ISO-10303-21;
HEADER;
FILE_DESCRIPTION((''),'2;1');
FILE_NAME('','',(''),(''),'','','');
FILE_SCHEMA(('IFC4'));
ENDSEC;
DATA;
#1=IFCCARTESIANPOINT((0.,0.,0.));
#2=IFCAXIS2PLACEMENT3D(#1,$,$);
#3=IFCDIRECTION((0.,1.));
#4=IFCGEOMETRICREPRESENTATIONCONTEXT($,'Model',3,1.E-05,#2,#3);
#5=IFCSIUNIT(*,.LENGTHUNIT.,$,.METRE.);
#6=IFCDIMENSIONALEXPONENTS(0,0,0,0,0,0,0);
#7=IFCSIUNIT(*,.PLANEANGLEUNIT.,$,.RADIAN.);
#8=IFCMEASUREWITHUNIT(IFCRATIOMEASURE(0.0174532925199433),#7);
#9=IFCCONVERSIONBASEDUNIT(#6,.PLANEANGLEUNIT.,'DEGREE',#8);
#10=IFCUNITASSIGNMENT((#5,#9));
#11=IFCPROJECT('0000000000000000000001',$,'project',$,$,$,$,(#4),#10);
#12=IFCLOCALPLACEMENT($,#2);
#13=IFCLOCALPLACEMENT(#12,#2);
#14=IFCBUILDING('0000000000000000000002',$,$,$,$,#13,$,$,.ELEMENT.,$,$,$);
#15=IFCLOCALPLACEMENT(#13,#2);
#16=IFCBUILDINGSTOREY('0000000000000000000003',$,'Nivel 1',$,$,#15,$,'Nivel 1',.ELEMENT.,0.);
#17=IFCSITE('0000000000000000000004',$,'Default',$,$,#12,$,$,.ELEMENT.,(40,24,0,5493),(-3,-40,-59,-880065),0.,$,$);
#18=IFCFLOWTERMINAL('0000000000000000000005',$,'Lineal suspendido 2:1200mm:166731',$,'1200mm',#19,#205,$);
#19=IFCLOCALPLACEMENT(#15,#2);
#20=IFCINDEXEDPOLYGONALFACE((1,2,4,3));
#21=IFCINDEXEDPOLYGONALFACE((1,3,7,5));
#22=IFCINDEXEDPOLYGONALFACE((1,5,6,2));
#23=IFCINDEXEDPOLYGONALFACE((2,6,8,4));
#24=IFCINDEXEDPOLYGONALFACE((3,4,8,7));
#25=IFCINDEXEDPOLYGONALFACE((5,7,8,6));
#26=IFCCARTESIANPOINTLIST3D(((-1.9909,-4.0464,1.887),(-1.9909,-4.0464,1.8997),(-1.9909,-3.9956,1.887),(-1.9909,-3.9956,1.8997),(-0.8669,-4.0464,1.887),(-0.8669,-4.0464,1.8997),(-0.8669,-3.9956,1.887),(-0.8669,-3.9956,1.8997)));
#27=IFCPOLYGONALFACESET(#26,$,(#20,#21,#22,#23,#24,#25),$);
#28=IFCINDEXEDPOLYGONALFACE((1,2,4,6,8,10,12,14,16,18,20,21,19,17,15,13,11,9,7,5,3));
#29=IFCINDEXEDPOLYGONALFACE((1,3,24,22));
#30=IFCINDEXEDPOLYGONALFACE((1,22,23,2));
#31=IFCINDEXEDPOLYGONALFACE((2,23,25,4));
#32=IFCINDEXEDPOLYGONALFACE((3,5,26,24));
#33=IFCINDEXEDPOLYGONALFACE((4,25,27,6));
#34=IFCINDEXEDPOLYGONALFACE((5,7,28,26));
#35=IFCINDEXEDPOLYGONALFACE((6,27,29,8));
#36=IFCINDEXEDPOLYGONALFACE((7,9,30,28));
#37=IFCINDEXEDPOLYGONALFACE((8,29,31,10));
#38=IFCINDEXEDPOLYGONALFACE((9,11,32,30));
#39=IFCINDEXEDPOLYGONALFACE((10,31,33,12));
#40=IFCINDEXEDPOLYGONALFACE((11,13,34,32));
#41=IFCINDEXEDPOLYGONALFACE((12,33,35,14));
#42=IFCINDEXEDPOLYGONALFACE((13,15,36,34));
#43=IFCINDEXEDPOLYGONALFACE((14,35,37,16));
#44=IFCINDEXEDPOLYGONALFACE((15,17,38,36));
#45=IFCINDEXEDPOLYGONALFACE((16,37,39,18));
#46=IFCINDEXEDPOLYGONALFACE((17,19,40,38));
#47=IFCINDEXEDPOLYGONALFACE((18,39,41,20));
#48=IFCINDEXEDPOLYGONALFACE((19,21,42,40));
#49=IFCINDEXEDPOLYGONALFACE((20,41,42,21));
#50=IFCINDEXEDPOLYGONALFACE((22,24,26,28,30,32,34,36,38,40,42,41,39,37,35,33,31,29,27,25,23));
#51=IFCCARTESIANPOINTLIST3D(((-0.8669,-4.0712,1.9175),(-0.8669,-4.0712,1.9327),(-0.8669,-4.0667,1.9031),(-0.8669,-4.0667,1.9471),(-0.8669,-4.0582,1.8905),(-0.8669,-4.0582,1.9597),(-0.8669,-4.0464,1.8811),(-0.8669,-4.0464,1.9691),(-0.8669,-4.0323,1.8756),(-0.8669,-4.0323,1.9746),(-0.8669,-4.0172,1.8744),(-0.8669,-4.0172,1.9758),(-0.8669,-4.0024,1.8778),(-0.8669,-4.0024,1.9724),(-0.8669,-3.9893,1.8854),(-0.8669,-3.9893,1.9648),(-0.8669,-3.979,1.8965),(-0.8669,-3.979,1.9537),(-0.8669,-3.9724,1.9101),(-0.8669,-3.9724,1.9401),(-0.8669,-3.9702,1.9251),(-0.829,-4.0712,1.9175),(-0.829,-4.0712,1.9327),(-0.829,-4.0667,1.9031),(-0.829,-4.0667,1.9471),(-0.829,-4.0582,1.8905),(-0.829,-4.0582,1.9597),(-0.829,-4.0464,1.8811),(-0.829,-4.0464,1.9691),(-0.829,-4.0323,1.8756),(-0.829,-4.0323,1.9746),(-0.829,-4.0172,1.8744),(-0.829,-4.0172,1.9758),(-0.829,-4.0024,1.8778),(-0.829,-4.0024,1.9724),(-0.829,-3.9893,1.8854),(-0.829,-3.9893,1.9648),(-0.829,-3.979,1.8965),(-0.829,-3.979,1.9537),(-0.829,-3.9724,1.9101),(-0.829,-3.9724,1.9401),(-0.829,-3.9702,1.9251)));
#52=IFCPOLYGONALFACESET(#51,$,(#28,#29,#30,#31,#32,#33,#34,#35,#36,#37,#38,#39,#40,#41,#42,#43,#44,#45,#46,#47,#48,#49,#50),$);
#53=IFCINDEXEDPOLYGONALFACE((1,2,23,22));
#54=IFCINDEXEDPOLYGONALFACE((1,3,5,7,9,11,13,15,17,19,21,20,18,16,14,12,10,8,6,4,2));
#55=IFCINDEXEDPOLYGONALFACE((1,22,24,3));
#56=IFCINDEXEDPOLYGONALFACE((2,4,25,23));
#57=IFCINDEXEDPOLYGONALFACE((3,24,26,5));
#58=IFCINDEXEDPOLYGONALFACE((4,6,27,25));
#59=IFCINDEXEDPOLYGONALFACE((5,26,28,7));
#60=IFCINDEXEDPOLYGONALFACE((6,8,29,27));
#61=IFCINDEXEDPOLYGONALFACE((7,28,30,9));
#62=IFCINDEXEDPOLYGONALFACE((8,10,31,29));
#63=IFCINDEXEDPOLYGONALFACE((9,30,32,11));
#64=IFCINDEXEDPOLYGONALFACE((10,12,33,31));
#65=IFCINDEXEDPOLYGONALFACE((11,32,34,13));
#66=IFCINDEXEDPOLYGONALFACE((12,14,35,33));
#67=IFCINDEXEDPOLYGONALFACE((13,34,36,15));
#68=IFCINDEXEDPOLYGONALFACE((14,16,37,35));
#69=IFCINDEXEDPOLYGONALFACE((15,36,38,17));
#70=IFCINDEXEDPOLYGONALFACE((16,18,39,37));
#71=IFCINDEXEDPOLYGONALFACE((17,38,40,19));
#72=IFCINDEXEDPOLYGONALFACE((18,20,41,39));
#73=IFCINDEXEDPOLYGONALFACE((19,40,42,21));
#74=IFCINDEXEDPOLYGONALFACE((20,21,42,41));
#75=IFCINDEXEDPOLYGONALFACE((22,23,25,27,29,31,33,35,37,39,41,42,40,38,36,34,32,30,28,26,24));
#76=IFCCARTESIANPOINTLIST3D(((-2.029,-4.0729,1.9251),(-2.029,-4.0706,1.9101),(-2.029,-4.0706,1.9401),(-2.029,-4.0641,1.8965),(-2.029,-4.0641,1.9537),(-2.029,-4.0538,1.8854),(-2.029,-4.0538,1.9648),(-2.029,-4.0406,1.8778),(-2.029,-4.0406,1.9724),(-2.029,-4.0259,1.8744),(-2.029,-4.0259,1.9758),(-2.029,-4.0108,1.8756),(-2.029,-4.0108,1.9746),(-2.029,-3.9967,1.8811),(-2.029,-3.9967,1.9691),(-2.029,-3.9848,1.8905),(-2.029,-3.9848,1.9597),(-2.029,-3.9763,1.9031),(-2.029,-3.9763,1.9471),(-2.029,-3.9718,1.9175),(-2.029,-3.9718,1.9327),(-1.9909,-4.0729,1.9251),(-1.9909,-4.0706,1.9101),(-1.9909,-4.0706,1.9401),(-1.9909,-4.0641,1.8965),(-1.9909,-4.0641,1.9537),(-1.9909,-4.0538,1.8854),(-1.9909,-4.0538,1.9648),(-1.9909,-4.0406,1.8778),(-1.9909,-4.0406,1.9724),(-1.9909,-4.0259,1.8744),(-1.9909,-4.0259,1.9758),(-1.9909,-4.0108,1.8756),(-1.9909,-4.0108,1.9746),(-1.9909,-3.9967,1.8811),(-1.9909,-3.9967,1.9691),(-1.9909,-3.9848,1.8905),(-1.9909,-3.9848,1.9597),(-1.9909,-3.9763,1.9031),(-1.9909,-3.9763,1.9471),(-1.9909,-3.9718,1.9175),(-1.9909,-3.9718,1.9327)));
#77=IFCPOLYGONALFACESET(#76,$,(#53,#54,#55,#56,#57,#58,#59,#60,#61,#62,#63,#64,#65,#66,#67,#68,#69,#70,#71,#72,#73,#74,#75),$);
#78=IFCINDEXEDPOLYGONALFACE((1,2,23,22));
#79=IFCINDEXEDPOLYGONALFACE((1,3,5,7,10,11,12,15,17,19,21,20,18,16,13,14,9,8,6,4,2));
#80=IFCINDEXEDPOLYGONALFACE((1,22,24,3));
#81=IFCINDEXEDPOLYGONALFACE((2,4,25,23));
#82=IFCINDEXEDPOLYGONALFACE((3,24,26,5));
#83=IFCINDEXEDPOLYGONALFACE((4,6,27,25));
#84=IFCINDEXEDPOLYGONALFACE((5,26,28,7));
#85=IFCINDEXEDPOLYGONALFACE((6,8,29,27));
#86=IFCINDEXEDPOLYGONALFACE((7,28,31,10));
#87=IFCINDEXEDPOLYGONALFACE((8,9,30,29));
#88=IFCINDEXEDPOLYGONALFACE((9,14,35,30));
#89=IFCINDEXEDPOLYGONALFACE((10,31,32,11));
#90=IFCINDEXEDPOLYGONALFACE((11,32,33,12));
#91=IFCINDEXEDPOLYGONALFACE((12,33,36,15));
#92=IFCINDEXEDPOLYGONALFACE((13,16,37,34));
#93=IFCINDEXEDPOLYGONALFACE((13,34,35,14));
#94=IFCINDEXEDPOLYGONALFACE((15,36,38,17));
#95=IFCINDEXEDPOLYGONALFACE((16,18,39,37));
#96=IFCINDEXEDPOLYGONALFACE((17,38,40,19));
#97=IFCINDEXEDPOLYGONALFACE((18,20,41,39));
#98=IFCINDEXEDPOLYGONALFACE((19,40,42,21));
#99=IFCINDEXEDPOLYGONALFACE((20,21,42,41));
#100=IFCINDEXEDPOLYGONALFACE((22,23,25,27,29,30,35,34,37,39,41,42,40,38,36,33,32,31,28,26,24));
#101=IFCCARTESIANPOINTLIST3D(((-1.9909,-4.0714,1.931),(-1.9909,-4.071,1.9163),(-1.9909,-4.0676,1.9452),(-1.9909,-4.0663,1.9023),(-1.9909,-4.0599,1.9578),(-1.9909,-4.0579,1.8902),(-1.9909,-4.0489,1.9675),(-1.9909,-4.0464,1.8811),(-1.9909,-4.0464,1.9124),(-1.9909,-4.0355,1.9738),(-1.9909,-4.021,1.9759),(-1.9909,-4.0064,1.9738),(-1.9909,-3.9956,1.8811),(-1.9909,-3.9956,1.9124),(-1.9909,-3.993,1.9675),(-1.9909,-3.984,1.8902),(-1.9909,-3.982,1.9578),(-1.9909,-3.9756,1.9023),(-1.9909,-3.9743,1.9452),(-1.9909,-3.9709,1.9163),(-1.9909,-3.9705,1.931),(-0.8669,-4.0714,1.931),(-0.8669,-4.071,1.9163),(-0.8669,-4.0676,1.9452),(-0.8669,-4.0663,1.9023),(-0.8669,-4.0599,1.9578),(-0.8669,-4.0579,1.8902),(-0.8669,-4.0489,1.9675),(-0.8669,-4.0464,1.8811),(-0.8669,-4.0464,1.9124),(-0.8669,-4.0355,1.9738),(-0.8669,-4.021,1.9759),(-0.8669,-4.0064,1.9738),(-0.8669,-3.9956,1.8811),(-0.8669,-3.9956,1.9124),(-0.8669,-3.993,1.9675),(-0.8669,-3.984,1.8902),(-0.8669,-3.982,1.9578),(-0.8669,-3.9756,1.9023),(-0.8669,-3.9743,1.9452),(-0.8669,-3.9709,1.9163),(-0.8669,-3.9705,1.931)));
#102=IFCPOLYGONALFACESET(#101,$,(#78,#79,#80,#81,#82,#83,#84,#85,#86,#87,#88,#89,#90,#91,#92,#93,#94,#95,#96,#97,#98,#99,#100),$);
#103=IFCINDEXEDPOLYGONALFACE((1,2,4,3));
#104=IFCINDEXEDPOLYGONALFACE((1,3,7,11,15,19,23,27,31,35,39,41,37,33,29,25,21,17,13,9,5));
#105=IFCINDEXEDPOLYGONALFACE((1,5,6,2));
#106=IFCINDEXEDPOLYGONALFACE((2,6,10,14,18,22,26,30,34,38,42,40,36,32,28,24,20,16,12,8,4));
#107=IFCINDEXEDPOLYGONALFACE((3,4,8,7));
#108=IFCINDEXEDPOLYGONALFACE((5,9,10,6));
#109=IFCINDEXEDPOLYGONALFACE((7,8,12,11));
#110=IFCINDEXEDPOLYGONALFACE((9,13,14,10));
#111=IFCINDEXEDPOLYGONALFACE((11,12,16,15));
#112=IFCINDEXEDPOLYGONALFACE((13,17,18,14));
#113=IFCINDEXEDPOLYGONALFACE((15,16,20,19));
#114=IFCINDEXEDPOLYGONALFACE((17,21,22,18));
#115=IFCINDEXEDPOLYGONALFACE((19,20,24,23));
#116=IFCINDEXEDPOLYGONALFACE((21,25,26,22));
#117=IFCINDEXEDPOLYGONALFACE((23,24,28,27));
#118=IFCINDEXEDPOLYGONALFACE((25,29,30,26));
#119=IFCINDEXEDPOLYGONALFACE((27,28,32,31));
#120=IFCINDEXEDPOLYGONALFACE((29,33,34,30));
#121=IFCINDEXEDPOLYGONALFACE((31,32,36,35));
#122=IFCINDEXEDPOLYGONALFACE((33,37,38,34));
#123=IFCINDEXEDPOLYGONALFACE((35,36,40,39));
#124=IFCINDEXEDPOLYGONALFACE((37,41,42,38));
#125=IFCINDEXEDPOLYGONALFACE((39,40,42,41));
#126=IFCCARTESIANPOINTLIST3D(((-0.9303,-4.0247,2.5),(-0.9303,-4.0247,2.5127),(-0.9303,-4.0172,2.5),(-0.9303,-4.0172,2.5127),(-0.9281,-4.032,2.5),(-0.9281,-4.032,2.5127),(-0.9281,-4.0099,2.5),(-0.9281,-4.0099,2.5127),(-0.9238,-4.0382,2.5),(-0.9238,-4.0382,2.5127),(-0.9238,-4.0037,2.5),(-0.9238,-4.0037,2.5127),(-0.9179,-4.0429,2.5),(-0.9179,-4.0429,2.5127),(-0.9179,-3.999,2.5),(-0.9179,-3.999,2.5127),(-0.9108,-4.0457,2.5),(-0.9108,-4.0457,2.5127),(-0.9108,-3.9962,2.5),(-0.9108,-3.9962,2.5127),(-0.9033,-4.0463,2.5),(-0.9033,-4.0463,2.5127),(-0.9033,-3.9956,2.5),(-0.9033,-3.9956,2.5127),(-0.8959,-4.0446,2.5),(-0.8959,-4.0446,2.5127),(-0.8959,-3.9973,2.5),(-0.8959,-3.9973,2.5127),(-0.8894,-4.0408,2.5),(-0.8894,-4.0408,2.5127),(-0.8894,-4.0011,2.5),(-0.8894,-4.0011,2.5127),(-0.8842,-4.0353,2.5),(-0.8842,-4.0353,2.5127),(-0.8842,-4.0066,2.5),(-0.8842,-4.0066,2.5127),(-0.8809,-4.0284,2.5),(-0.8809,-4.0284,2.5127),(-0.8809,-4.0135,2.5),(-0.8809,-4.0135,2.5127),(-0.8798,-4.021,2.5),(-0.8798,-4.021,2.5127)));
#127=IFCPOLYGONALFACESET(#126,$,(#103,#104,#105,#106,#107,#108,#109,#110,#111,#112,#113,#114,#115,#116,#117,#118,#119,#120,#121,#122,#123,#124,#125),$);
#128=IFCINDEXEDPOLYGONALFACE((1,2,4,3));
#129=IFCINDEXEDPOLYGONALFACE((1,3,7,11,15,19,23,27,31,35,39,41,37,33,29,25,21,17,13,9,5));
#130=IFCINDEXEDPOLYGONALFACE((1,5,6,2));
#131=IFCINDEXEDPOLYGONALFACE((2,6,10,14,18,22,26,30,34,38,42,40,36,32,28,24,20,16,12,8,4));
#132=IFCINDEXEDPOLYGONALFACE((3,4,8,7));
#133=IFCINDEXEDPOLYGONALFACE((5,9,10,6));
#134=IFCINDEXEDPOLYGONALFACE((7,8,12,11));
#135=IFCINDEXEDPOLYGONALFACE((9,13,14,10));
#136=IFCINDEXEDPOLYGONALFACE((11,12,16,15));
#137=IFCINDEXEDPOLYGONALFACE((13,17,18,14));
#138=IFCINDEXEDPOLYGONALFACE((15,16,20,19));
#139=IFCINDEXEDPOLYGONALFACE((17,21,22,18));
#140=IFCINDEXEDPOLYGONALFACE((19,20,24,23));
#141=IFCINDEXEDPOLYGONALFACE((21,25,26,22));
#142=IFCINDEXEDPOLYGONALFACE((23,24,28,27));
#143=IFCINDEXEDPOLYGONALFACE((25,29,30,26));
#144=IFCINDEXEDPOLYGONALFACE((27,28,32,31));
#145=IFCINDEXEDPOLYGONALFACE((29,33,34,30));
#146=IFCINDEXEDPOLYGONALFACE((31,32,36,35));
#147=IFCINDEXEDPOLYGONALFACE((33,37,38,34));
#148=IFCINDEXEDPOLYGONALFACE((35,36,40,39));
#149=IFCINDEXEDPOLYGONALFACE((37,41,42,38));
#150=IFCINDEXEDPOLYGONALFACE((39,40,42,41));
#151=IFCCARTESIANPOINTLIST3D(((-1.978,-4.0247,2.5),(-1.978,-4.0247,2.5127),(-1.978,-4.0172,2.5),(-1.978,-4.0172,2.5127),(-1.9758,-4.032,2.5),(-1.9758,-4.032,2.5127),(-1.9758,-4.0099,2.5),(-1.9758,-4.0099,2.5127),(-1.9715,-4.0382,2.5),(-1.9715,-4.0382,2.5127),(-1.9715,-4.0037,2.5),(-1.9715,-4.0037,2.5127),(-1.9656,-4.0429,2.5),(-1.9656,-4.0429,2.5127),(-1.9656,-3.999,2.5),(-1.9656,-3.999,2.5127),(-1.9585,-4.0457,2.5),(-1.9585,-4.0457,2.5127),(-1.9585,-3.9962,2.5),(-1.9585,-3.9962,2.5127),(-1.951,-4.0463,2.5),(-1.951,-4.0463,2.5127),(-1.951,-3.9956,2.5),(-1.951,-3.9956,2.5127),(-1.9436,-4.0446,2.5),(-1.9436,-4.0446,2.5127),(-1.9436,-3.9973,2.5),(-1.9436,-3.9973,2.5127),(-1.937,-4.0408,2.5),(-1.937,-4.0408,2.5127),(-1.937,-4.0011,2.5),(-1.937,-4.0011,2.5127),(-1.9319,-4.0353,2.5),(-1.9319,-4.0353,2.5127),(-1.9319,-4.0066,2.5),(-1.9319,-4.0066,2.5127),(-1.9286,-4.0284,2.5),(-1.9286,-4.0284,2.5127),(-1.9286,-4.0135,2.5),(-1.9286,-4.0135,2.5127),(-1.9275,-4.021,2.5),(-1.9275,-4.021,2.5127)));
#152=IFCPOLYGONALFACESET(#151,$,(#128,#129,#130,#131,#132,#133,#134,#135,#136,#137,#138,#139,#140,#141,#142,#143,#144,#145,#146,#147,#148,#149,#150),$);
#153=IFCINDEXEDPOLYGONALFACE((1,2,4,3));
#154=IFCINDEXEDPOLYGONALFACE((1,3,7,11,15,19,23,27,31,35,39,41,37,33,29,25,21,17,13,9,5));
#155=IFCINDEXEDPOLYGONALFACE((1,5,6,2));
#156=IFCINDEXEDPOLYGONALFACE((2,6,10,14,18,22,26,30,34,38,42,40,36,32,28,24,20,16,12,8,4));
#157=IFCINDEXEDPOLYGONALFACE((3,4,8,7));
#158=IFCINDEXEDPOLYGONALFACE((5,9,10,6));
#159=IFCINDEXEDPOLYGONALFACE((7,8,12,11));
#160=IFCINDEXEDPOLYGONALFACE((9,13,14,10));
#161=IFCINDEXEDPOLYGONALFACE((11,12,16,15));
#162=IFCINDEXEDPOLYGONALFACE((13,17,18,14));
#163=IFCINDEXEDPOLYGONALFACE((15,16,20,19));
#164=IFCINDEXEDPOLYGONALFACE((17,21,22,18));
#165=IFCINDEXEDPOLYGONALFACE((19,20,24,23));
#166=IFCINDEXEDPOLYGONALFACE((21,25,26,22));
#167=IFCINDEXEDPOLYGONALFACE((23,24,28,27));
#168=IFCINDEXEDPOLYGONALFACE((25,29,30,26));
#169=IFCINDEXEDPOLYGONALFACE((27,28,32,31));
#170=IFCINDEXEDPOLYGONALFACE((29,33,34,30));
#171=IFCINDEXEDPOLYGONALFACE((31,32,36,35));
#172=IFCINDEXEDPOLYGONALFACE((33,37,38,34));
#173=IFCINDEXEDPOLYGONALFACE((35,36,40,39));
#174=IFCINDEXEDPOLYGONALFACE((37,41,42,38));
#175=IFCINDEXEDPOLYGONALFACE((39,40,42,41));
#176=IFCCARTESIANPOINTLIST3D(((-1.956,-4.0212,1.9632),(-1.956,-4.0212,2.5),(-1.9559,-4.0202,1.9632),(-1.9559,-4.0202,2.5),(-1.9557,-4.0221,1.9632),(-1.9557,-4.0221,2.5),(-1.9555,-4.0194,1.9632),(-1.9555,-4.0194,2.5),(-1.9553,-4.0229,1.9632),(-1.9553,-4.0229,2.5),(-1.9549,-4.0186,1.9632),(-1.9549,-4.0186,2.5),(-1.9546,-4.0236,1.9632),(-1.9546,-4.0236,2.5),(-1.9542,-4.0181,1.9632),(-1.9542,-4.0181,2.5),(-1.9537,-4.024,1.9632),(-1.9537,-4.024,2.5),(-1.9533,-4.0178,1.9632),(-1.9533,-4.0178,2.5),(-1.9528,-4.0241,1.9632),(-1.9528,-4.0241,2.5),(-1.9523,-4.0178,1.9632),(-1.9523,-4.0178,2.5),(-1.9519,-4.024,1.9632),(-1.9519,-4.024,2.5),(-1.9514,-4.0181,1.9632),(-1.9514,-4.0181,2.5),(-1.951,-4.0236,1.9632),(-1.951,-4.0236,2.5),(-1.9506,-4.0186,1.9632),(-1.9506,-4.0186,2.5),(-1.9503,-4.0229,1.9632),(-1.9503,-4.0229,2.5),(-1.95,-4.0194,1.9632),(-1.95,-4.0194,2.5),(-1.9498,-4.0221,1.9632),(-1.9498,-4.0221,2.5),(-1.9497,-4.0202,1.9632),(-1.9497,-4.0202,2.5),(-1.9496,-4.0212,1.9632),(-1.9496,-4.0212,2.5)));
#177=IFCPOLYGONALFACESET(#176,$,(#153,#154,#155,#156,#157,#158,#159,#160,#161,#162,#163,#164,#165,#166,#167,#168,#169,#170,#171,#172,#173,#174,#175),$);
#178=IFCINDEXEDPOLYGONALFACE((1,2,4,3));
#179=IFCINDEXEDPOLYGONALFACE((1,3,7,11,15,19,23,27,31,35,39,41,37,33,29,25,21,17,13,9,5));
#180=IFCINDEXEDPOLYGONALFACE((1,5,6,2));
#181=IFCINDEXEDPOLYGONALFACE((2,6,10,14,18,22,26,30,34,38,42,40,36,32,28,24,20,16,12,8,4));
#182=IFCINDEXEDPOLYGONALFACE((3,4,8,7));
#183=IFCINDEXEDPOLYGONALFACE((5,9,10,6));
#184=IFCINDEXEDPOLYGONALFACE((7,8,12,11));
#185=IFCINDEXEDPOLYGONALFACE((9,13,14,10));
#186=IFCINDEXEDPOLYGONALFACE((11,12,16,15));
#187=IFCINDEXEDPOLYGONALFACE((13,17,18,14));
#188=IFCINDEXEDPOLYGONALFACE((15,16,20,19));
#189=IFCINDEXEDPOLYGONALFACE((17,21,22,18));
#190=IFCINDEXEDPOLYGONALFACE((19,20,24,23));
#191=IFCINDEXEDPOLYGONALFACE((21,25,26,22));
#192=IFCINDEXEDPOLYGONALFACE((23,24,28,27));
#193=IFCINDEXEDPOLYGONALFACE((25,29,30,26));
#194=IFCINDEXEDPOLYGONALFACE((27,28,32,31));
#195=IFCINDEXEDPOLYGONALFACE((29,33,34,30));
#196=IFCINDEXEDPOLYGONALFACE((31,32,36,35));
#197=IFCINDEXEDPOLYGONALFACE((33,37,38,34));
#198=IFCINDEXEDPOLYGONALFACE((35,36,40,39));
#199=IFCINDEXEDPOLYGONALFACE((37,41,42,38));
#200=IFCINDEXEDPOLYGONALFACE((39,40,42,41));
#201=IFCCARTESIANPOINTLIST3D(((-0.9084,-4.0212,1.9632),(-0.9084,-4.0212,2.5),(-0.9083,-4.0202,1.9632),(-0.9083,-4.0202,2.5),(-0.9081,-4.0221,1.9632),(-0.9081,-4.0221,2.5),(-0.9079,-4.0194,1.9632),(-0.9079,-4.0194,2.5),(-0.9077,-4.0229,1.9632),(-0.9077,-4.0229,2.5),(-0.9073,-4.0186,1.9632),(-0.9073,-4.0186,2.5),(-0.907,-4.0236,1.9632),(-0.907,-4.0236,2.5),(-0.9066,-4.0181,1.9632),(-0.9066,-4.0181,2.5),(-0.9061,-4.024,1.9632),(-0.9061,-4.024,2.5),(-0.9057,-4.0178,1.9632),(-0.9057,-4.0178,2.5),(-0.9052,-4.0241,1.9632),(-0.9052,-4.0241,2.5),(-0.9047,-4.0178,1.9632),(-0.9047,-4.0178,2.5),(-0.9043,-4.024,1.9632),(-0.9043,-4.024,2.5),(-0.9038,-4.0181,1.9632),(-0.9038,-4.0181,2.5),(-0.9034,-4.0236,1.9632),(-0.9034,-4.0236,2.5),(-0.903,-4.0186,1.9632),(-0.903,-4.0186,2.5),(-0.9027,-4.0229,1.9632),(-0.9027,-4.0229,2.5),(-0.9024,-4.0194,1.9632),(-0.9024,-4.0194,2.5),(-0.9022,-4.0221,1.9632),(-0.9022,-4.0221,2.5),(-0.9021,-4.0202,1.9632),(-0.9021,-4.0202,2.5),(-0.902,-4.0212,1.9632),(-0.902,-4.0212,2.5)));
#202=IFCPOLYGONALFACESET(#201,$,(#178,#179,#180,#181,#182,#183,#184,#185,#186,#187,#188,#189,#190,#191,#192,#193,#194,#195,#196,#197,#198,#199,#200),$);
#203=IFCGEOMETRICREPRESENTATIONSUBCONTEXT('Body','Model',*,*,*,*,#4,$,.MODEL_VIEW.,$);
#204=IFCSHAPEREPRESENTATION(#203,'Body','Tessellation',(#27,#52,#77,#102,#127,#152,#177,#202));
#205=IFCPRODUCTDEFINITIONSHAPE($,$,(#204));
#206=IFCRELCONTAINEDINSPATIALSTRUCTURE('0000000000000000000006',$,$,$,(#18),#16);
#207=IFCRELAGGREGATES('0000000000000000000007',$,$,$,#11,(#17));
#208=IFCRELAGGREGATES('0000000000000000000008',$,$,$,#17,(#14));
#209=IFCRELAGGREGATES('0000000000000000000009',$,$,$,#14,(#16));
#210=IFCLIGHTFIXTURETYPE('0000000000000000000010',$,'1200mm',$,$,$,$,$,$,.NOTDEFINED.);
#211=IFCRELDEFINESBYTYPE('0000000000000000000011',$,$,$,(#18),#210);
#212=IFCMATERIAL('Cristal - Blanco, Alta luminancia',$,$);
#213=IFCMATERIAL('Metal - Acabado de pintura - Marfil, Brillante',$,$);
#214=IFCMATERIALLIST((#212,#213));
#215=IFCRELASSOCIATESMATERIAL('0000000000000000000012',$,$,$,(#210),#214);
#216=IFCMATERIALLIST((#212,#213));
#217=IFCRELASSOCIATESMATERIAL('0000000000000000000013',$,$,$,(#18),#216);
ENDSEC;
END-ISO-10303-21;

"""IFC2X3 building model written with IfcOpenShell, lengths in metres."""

from ifc_helpers import new_model, entity, si_unit, converted_unit, direction, frame, frame_2d, origin, origin_2d_with_axis, place, context, subcontext, project, spatial, polyline, circle_curve, parameter, trimmed, segment, composite_curve, rectangle, circle, outline, extrude, source, transform, mapped, material, material_list, type_object, type_shapes, element, save


model = new_model("IFC2X3")

# Units and contexts
model_context = context("Model", 3, precision=1e-05, world=origin(), true_north=direction((0.0, 1.0)))
body_context = subcontext(model_context, "Body", "Model", "MODEL_VIEW")
ifc_project = project(units=[si_unit("LENGTHUNIT", "METRE"), converted_unit("PLANEANGLEUNIT", "DEGREE", entity("IfcRatioMeasure", 0.0174532925199433), si_unit("PLANEANGLEUNIT", "RADIAN"), dimensions=[0, 0, 0, 0, 0, 0, 0])], contexts=[model_context])

# Site, building, storey
site_placement = place(None, origin())
site = spatial("IfcSite", under=ifc_project, at=site_placement, Name="Default", CompositionType="ELEMENT", RefLatitude=(40, 24, 0, 5493), RefLongitude=(-3, -40, -59, -880065), RefElevation=0.0)
building_placement = place(site_placement, origin())
building = spatial("IfcBuilding", under=site, at=building_placement, CompositionType="ELEMENT")
storey_placement = place(building_placement, origin())
storey = spatial("IfcBuildingStorey", under=building, at=storey_placement, Name="Nivel 1", LongName="Nivel 1", CompositionType="ELEMENT", Elevation=0.0)

# Flow terminal
ifc_material_1 = material(Name="Cristal - Blanco, Alta luminancia")
ifc_material_2 = material(Name="Metal - Acabado de pintura - Marfil, Brillante")
ifc_material_list_1 = material_list([ifc_material_1, ifc_material_2])
light_fixture_type = type_object("IfcLightFixtureType", Name="1200mm", PredefinedType="NOTDEFINED", material=ifc_material_list_1)
shared_shape = source(origin(), body_context, "Body", "SweptSolid", [
    extrude(rectangle(XDim=1.124, YDim=0.0508, at=origin_2d_with_axis()), frame((0.0001, 0.0, 1.8127), z_axis=(0.0, 0.0, 1.0), x_axis=(-1.0, 0.0, 0.0)), (0.0, 0.0, 1.0), 0.0127),
    extrude(circle(Radius=0.0508, at=frame_2d((0.0, 0.0), x_axis=(1.0, 0.0))), frame((0.5621, 0.0, 1.8508), z_axis=(1.0, 0.0, 0.0), x_axis=(0.0, 1.0, 0.0)), (0.0, 0.0, 1.0), 0.0379),
    extrude(circle(Radius=0.0508, at=frame_2d((0.0, 0.0), x_axis=(1.0, 0.0))), frame((-0.6, -0.0011, 1.8508), z_axis=(1.0, 0.0, 0.0), x_axis=(0.0, -1.0, 0.0)), (0.0, 0.0, 1.0), 0.0381),
    extrude(outline(composite_curve([segment(trimmed(circle_curve(frame_2d((0.0125, 0.0), x_axis=(0.0, 1.0)), 0.0508), [parameter(120.0)], [parameter(270.0)], True, "PARAMETER"), True, "CONTINUOUS"), segment(trimmed(circle_curve(frame_2d((0.0125, 0.0), x_axis=(0.0, 1.0)), 0.0508), [parameter(270.0)], [parameter(60.0)], True, "PARAMETER"), True, "CONTINUOUS"), segment(polyline([(-0.0315, 0.0254), (-0.0002, 0.0254)]), True, "CONTINUOUS"), segment(polyline([(-0.0002, 0.0254), (-0.0002, -0.0254)]), True, "CONTINUOUS"), segment(polyline([(-0.0002, -0.0254), (-0.0315, -0.0254)]), True, "CONTINUOUS")], self_intersect=False)), frame((-0.5619, 0.0, 1.8383), z_axis=(-1.0, 0.0, 0.0), x_axis=(0.0, 0.0, 1.0)), (0.0, 0.0, -1.0), 1.124),
    extrude(circle(Radius=0.0254, at=frame_2d((0.0, 0.0), x_axis=(1.0, 0.0))), frame((0.5238, 0.0, 2.4257)), (0.0, 0.0, 1.0), 0.0127),
    extrude(circle(Radius=0.0254, at=frame_2d((0.0, 0.0), x_axis=(1.0, 0.0))), frame((-0.5239, 0.0, 2.4257)), (0.0, 0.0, 1.0), 0.0127),
    extrude(circle(Radius=0.0032, at=frame_2d((0.0, 0.0), x_axis=(1.0, 0.0))), frame((-0.5238, 0.0, 1.8889), z_axis=(0.0, 0.0, 1.0), x_axis=(0.0, -1.0, 0.0)), (0.0, 0.0, 1.0), 0.5368),
    extrude(circle(Radius=0.0032, at=frame_2d((0.0, 0.0), x_axis=(1.0, 0.0))), frame((0.5238, 0.0, 1.8889), z_axis=(0.0, 0.0, 1.0), x_axis=(0.0, -1.0, 0.0)), (0.0, 0.0, 1.0), 0.5368),
])
type_shapes(light_fixture_type, [shared_shape])
ifc_material_list_2 = material_list([ifc_material_1, ifc_material_2])
flow_terminal_1_placement = place(storey_placement, frame((-1.429, -4.021, 0.0743)))
element("IfcFlowTerminal", 1, at=flow_terminal_1_placement, inside=storey, type_object=light_fixture_type, material=ifc_material_list_2, Name="Lineal suspendido 2:1200mm:166731", ObjectType="1200mm", context=body_context, shape_type="MappedRepresentation", body=[
    mapped(shared_shape, transform((0.0, 0.0, 0.0), scale=1.0)),
])

save(model, "model.ifc")
